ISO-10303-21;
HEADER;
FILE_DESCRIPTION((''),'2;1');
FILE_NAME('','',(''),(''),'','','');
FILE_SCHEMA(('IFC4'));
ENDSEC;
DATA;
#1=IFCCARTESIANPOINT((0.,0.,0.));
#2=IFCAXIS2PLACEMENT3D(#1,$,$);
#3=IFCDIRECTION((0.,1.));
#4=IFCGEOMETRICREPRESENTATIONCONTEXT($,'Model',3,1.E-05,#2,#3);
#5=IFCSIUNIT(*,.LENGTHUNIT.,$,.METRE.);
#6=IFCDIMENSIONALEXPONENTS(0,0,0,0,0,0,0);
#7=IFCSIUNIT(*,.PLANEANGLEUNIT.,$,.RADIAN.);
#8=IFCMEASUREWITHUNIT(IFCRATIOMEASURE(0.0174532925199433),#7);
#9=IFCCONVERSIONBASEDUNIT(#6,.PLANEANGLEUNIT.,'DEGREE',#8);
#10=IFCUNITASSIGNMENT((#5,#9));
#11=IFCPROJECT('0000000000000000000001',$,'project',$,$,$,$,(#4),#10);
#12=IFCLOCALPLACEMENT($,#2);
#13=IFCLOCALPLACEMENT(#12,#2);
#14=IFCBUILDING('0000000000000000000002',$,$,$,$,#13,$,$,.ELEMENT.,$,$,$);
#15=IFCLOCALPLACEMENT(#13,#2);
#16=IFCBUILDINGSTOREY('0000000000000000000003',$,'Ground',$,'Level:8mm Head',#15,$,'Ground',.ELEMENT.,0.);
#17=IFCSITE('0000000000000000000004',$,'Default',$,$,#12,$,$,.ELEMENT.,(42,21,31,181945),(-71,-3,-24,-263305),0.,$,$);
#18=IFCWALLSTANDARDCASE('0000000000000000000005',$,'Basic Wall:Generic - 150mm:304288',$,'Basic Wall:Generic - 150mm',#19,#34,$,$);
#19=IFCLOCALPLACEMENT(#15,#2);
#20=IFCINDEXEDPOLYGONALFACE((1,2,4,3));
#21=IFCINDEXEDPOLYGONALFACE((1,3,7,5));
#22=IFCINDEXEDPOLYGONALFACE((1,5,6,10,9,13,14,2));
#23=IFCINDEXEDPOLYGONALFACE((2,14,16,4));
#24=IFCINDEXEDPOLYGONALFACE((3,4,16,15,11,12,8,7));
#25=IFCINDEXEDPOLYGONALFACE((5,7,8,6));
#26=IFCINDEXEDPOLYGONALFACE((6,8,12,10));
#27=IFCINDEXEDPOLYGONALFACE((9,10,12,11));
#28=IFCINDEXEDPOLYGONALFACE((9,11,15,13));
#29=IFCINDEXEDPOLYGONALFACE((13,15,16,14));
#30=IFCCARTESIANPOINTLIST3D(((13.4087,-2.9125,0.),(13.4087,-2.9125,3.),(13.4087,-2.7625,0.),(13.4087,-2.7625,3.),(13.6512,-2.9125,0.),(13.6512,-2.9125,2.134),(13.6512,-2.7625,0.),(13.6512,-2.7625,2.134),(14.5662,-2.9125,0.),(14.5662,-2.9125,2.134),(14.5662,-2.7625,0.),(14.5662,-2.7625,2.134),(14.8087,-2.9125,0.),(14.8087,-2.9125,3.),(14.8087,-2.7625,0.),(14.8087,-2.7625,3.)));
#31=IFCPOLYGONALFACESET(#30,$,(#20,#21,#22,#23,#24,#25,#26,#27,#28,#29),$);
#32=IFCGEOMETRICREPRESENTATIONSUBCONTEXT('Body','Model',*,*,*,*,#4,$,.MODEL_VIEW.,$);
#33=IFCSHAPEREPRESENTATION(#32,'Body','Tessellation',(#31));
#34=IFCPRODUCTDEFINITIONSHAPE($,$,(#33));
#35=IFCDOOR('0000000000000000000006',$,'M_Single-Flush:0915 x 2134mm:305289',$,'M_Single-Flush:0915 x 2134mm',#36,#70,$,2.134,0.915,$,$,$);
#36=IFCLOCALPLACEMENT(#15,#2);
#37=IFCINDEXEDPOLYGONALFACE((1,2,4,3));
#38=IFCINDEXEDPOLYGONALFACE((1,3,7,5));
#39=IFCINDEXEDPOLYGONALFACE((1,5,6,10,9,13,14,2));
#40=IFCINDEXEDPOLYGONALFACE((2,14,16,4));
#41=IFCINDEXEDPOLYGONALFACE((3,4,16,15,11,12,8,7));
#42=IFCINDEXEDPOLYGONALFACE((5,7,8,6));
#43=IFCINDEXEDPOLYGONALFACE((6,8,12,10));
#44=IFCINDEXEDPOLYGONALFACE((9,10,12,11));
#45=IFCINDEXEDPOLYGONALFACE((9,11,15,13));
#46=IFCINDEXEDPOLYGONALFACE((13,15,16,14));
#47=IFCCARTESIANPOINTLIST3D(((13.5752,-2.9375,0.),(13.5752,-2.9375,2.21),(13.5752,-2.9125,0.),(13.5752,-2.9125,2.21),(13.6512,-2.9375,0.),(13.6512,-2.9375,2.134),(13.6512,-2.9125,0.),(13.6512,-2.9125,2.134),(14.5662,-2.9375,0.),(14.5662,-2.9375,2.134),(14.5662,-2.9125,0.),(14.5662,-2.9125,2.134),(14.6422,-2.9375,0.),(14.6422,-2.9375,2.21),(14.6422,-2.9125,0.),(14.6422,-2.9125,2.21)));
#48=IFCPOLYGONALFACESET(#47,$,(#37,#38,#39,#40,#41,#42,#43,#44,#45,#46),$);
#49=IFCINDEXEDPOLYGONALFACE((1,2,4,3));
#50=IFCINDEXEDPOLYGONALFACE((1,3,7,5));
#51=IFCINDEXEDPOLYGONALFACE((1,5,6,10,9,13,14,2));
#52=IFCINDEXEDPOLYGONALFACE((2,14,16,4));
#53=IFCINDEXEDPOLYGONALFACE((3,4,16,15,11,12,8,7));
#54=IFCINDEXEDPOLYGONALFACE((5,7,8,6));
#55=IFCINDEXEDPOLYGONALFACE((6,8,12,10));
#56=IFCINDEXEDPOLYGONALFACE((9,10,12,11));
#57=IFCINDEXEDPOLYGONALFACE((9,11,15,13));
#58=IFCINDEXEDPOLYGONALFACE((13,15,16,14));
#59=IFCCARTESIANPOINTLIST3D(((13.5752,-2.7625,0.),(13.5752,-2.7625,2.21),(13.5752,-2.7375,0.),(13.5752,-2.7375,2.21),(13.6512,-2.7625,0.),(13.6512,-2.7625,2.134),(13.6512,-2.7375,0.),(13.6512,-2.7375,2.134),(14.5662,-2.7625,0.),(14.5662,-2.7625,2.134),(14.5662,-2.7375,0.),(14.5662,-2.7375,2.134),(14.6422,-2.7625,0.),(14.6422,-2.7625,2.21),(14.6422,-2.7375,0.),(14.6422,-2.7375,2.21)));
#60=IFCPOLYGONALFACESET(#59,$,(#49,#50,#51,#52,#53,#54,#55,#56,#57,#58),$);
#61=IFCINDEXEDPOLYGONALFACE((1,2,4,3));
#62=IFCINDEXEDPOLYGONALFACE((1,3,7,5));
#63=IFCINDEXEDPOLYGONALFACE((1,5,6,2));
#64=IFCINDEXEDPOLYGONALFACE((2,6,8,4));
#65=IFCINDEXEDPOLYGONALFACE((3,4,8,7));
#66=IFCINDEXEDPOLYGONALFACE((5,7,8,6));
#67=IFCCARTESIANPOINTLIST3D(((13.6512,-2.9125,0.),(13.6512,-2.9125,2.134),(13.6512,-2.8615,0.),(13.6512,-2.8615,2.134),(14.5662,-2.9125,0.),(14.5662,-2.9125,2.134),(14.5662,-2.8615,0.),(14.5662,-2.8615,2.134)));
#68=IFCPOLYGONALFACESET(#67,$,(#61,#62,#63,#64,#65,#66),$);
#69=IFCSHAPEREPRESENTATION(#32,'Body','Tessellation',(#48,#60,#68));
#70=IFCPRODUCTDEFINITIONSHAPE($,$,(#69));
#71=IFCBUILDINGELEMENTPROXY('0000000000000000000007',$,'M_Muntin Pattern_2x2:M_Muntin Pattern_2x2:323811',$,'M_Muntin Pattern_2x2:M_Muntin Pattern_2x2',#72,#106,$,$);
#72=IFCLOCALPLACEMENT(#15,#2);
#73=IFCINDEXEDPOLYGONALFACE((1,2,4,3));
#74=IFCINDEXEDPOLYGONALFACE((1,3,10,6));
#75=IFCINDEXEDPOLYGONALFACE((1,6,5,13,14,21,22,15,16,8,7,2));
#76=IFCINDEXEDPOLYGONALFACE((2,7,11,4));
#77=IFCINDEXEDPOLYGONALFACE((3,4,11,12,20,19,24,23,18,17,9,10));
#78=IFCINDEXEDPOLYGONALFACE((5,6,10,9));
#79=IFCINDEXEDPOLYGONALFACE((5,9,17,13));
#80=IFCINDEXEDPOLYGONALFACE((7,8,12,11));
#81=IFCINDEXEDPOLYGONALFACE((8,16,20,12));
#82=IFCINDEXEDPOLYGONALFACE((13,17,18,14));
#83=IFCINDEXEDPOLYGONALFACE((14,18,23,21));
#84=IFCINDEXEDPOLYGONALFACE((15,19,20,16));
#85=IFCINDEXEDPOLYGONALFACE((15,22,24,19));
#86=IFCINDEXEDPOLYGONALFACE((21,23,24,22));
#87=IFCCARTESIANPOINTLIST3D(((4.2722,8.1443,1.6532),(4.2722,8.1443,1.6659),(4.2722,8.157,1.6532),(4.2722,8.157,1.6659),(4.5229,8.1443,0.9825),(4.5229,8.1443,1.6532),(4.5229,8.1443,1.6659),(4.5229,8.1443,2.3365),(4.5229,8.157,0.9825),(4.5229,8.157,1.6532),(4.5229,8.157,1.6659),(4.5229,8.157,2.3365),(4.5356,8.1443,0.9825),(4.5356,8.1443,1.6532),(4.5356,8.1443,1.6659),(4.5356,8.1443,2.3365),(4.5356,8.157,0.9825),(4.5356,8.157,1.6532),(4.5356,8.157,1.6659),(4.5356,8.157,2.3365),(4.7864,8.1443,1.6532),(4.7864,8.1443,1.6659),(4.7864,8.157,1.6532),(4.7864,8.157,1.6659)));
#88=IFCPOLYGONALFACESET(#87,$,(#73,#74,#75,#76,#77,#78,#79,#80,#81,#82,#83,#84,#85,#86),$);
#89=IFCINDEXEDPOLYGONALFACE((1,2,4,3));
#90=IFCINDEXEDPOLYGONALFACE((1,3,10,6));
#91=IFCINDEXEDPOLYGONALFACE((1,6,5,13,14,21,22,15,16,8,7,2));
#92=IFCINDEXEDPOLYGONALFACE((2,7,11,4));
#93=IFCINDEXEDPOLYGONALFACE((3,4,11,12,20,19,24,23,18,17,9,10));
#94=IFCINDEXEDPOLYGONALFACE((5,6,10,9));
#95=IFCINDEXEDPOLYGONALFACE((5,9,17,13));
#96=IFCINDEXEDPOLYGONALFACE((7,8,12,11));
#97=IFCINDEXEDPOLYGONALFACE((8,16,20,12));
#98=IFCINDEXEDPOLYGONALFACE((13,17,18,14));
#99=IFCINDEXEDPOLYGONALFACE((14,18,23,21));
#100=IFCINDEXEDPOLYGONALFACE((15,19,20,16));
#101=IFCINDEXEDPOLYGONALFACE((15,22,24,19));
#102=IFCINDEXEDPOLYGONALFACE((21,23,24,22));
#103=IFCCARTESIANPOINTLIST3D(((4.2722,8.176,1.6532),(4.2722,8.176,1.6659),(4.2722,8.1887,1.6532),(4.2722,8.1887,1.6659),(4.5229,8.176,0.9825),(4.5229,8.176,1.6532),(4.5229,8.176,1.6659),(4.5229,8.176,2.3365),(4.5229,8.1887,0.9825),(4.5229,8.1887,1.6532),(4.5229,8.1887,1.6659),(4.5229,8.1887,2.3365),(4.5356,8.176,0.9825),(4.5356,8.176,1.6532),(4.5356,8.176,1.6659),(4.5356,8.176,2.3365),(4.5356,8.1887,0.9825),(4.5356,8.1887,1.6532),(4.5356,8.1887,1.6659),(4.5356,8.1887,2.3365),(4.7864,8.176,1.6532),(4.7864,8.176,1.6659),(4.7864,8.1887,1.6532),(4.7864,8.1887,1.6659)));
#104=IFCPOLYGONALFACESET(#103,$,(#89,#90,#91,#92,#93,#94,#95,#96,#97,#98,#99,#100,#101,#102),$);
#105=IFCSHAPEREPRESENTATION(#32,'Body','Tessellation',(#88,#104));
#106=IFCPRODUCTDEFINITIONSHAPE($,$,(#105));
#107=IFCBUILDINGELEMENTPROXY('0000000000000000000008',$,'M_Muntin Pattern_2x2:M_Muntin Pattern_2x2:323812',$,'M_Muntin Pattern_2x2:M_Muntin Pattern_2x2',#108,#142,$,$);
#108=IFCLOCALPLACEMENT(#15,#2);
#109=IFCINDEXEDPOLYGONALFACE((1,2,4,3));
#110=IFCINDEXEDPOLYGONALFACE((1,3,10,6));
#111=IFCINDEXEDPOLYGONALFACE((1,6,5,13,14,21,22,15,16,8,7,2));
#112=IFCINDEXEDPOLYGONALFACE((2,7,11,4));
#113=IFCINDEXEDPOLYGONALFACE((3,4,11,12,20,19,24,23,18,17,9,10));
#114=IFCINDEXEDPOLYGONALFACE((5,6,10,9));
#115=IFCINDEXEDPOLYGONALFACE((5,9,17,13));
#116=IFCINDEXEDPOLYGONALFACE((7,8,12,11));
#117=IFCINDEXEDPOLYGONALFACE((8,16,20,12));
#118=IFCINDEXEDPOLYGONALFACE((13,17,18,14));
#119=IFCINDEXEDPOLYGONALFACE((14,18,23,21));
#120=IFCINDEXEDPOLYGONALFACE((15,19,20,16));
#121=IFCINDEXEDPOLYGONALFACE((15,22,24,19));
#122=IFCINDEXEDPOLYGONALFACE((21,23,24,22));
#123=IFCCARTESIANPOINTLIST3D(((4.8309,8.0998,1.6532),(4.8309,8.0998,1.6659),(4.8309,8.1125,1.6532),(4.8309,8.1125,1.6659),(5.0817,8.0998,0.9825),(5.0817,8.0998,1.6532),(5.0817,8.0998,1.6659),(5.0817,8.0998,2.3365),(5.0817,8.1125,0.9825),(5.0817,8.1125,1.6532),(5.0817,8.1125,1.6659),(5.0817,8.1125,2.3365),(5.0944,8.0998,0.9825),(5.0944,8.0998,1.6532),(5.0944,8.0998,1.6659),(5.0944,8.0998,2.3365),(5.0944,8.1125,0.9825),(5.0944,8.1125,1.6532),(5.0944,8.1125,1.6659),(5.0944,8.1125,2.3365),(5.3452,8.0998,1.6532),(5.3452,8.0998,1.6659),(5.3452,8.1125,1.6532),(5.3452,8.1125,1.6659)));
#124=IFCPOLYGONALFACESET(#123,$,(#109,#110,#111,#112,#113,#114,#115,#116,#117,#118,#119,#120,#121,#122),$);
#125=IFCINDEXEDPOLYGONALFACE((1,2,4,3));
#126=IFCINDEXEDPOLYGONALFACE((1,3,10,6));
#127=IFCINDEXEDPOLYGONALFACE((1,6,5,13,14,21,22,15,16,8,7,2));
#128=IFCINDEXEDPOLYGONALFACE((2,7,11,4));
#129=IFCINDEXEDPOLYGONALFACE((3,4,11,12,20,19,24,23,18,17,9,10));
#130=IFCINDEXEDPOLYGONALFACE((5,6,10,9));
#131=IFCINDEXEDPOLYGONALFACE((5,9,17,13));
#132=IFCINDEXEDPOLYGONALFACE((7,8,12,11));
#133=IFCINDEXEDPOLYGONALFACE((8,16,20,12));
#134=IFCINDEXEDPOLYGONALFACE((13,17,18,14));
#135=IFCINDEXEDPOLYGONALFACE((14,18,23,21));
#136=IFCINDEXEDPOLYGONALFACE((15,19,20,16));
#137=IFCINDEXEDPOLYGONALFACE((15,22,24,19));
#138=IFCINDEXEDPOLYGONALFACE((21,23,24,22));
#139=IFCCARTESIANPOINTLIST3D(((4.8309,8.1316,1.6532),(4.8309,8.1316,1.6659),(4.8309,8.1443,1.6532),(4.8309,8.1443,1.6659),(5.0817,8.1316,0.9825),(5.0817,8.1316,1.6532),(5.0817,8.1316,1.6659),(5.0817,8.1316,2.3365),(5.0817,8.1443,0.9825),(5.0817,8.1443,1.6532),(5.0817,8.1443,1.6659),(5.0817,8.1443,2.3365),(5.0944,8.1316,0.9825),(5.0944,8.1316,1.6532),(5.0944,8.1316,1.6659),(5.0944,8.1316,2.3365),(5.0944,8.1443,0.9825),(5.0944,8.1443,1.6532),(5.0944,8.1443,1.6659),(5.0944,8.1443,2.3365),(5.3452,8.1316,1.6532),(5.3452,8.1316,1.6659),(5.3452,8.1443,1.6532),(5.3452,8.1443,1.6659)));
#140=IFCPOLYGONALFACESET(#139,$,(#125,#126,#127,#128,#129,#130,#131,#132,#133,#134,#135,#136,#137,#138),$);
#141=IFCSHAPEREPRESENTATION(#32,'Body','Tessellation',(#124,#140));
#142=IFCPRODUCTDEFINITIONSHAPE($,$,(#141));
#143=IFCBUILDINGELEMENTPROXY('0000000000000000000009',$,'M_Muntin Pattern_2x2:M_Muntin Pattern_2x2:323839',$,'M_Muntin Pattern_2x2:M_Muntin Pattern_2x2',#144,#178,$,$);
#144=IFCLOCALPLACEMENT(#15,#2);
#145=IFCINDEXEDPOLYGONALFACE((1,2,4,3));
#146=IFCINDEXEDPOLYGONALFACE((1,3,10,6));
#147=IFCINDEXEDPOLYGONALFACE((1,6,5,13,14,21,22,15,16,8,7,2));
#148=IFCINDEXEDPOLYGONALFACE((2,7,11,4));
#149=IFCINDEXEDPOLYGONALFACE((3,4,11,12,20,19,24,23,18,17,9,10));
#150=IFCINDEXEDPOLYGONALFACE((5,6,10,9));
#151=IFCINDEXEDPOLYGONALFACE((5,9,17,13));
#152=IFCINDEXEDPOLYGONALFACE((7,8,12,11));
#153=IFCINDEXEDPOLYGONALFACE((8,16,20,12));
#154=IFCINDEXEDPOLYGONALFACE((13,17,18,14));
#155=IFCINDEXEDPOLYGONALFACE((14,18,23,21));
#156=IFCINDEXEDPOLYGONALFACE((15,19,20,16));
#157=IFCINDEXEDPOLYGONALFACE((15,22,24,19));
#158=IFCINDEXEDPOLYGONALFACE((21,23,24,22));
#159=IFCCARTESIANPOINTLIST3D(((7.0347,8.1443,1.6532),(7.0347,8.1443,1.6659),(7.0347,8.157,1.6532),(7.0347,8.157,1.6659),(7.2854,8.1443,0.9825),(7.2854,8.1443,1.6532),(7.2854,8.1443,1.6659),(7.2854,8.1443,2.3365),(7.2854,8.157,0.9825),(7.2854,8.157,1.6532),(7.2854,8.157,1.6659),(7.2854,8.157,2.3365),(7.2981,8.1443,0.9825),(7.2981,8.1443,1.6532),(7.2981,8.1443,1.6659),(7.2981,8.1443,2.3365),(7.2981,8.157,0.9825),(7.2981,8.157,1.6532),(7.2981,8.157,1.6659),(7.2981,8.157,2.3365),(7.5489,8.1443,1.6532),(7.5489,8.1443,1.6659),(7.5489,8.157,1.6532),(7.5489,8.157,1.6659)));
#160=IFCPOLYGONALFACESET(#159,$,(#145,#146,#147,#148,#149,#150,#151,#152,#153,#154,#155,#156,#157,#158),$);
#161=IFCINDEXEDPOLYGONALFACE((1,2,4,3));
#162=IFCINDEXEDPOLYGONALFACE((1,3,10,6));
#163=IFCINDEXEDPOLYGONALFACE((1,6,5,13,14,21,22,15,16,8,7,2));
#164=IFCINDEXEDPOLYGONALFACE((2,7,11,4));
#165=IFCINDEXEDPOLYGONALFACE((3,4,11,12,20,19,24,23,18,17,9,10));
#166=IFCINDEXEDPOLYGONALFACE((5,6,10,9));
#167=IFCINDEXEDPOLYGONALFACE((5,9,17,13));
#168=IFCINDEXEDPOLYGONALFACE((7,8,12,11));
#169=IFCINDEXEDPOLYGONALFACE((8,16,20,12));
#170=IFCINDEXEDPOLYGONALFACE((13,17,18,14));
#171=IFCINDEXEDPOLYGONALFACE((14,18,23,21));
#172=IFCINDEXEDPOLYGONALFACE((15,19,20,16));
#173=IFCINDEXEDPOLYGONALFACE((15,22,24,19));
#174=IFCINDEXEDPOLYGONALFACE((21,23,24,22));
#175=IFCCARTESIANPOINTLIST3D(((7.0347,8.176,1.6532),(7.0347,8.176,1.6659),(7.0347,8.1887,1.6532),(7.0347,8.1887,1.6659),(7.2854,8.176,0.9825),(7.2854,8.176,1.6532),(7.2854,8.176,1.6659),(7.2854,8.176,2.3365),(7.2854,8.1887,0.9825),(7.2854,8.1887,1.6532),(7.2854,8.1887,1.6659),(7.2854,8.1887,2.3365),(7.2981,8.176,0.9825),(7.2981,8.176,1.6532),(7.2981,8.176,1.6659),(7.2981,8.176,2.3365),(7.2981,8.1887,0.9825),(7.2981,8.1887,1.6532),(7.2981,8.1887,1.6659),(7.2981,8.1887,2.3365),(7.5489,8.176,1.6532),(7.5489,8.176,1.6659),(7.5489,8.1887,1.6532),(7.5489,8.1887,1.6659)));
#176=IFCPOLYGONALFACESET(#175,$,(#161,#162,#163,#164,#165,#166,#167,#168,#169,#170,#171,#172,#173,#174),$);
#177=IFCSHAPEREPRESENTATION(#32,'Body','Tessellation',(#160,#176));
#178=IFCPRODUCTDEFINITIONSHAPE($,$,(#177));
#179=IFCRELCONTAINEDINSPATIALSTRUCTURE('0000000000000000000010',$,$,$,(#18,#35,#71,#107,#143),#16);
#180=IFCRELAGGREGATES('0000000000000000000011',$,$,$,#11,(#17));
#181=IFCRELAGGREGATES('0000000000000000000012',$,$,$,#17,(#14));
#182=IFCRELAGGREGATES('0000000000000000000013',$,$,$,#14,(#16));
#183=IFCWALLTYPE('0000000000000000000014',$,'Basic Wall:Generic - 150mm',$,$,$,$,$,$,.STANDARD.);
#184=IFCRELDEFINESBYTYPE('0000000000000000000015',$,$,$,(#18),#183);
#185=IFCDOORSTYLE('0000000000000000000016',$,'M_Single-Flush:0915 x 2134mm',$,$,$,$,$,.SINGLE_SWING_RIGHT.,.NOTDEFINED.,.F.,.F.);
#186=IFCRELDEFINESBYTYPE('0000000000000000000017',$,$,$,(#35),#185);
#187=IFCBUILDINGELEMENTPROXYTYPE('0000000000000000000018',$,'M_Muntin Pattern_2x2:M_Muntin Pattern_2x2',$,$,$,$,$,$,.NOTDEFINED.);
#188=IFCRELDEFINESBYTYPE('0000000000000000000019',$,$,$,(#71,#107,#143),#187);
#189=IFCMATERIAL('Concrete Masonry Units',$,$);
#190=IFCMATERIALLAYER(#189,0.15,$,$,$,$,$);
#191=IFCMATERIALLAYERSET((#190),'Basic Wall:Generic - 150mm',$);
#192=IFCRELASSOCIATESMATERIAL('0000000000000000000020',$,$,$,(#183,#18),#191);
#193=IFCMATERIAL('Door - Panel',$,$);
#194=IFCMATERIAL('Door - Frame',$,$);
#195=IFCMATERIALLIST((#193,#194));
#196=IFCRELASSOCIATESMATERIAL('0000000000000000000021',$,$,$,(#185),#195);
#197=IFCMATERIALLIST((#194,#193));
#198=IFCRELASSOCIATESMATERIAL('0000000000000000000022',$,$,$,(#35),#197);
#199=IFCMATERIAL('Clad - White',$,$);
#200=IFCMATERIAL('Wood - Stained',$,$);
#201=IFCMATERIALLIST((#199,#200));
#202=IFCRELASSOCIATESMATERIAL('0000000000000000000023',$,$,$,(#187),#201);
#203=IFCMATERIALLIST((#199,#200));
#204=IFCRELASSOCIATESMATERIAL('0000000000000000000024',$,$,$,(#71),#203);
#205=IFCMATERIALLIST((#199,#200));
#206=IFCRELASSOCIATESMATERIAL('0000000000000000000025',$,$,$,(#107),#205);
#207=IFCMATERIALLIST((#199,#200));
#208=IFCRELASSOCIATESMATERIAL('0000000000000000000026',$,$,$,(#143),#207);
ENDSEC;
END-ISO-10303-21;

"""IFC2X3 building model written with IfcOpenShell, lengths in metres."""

from ifc_helpers import new_model, entity, si_unit, converted_unit, direction, frame, frame_2d, origin, place, context, subcontext, project, spatial, polyline, rectangle, outline, extrude, source, transform, mapped, material, material_list, layer, layer_set, layer_usage, type_object, type_shapes, element, fill, save


model = new_model("IFC2X3")

# Units and contexts
model_context = context("Model", 3, precision=1e-05, world=origin(), true_north=direction((0.0, 1.0)))
body_context = subcontext(model_context, "Body", "Model", "MODEL_VIEW")
ifc_project = project(units=[si_unit("LENGTHUNIT", "METRE"), converted_unit("PLANEANGLEUNIT", "DEGREE", entity("IfcRatioMeasure", 0.0174532925199433), si_unit("PLANEANGLEUNIT", "RADIAN"), dimensions=[0, 0, 0, 0, 0, 0, 0])], contexts=[model_context])

# Site, building, storey
site_placement = place(None, origin())
site = spatial("IfcSite", under=ifc_project, at=site_placement, Name="Default", CompositionType="ELEMENT", RefLatitude=(42, 21, 31, 181945), RefLongitude=(-71, -3, -24, -263305), RefElevation=0.0)
building_placement = place(site_placement, origin())
building = spatial("IfcBuilding", under=site, at=building_placement, CompositionType="ELEMENT")
storey_placement = place(building_placement, origin())
storey = spatial("IfcBuildingStorey", under=building, at=storey_placement, Name="Ground", ObjectType="Level:8mm Head", LongName="Ground", CompositionType="ELEMENT", Elevation=0.0)

# Shared definitions
ifc_material_1 = material(Name="Concrete Masonry Units")
ifc_layer = layer(ifc_material_1, 0.15)
ifc_layer_set = layer_set([ifc_layer], Name="Basic Wall:Generic - 150mm")
wall_type = type_object("IfcWallType", Name="Basic Wall:Generic - 150mm", PredefinedType="STANDARD", material=ifc_layer_set)

# Shared definitions
ifc_material_2 = material(Name="Door - Frame")
ifc_material_3 = material(Name="Door - Panel")

# Wall, opening, door
ifc_layer_usage_1 = layer_usage(ifc_layer_set, "AXIS2", "NEGATIVE", 0.075)
wall_1_placement = place(storey_placement, frame((14.8087, -2.8375, 0.0), z_axis=(0.0, 0.0, 1.0), x_axis=(-1.0, 0.0, 0.0)))
wall_1 = element("IfcWallStandardCase", 1, at=wall_1_placement, inside=storey, type_object=wall_type, material=ifc_layer_usage_1, Name="Basic Wall:Generic - 150mm:304288", ObjectType="Basic Wall:Generic - 150mm", context=body_context, shape_type="SweptSolid", body=[
    extrude(rectangle(XDim=1.4, YDim=0.15, at=frame_2d((0.7, 0.0), x_axis=(-1.0, 0.0))), origin(), (0.0, 0.0, 1.0), 3.0),
])
opening_1_placement = place(wall_1_placement, frame((0.2425, -0.075, 0.0)))
opening_1 = element("IfcOpeningElement", 2, at=opening_1_placement, cuts=wall_1, ObjectType="Opening", context=body_context, shape_type="SweptSolid", body=[
    extrude(rectangle(XDim=0.915, YDim=2.134, at=frame_2d((1.067, 0.4575), x_axis=(0.0, 1.0))), frame((0.0, 0.0, 0.0), z_axis=(0.0, 1.0, 0.0), x_axis=(0.0, 0.0, 1.0)), (0.0, 0.0, 1.0), 0.15),
])
ifc_material_list_1 = material_list([ifc_material_2, ifc_material_3])
ifc_material_list_2 = material_list([ifc_material_3, ifc_material_2])
door_style_1 = type_object("IfcDoorStyle", Name="M_Single-Flush:0915 x 2134mm", ConstructionType="NOTDEFINED", OperationType="SINGLE_SWING_RIGHT", ParameterTakesPrecedence=False, Sizeable=False, material=ifc_material_list_2)
shared_shape_1 = source(origin(), body_context, "Body", "SweptSolid", [
    extrude(outline(polyline([(-0.5335, -1.124), (0.5335, -1.124), (0.5335, 1.086), (0.4575, 1.086), (0.4575, -1.048), (-0.4575, -1.048), (-0.4575, 1.086), (-0.5335, 1.086), (-0.5335, -1.124)])), frame((0.4575, 0.15, 1.086), z_axis=(0.0, 1.0, 0.0), x_axis=(1.0, 0.0, 0.0)), (0.0, 0.0, 1.0), 0.025),
    extrude(outline(polyline([(-1.124, -0.5335), (1.086, -0.5335), (1.086, -0.4575), (-1.048, -0.4575), (-1.048, 0.4575), (1.086, 0.4575), (1.086, 0.5335), (-1.124, 0.5335), (-1.124, -0.5335)])), frame((0.4575, -0.025, 1.086), z_axis=(0.0, 1.0, 0.0), x_axis=(0.0, 0.0, -1.0)), (0.0, 0.0, 1.0), 0.025),
    extrude(rectangle(XDim=0.051, YDim=0.915, at=frame_2d((0.0, 0.0), x_axis=(1.0, 0.0))), frame((0.4575, 0.1245, 0.0), z_axis=(0.0, 0.0, 1.0), x_axis=(0.0, 1.0, 0.0)), (0.0, 0.0, 1.0), 2.134),
])
type_shapes(door_style_1, [shared_shape_1])
door_1_placement = place(opening_1_placement, origin())
door_1 = element("IfcDoor", 3, at=door_1_placement, inside=storey, type_object=door_style_1, material=ifc_material_list_1, Name="M_Single-Flush:0915 x 2134mm:305289", ObjectType="M_Single-Flush:0915 x 2134mm", OverallHeight=2.134, OverallWidth=0.915, context=body_context, shape_type="MappedRepresentation", body=[
    mapped(shared_shape_1, transform((0.0, 0.0, 0.0), scale=1.0)),
])
fill(opening_1, door_1)

# Building element proxies
ifc_material_4 = material(Name="Clad - White")
ifc_material_5 = material(Name="Wood - Stained")
ifc_material_list_3 = material_list([ifc_material_4, ifc_material_5])
ifc_material_list_4 = material_list([ifc_material_4, ifc_material_5])
building_element_proxy_type_1 = type_object("IfcBuildingElementProxyType", Name="M_Muntin Pattern_2x2:M_Muntin Pattern_2x2", PredefinedType="NOTDEFINED", material=ifc_material_list_4)
shared_shape_2 = source(origin(), body_context, "Body", "SweptSolid", [
    extrude(outline(polyline([(0.0064, -0.0064), (0.677, -0.0064), (0.677, 0.0063), (0.0064, 0.0063), (0.0064, 0.2571), (-0.0063, 0.2571), (-0.0063, 0.0063), (-0.677, 0.0063), (-0.677, -0.0064), (-0.0063, -0.0064), (-0.0063, -0.2571), (0.0064, -0.2571), (0.0064, -0.0064)])), frame((0.0, 0.0095, 0.677), z_axis=(0.0, 1.0, 0.0), x_axis=(0.0, 0.0, 1.0)), (0.0, 0.0, 1.0), 0.0127),
    extrude(outline(polyline([(0.0064, -0.0064), (0.677, -0.0064), (0.677, 0.0063), (0.0064, 0.0063), (0.0064, 0.2571), (-0.0063, 0.2571), (-0.0063, 0.0063), (-0.677, 0.0063), (-0.677, -0.0064), (-0.0063, -0.0064), (-0.0063, -0.2571), (0.0064, -0.2571), (0.0064, -0.0064)])), frame((0.0, -0.0222, 0.677), z_axis=(0.0, 1.0, 0.0), x_axis=(0.0, 0.0, 1.0)), (0.0, 0.0, 1.0), 0.0127),
])
type_shapes(building_element_proxy_type_1, [shared_shape_2])
proxy_1_placement = place(storey_placement, frame((4.5293, 8.1665, 0.9825), z_axis=(0.0, 0.0, 1.0), x_axis=(-1.0, 0.0, 0.0)))
element("IfcBuildingElementProxy", 4, at=proxy_1_placement, inside=storey, type_object=building_element_proxy_type_1, material=ifc_material_list_3, Name="M_Muntin Pattern_2x2:M_Muntin Pattern_2x2:323811", ObjectType="M_Muntin Pattern_2x2:M_Muntin Pattern_2x2", context=body_context, shape_type="MappedRepresentation", body=[
    mapped(shared_shape_2, transform((0.0, 0.0, 0.0), scale=1.0)),
])
ifc_material_list_5 = material_list([ifc_material_4, ifc_material_5])
proxy_2_placement = place(storey_placement, frame((5.088, 8.1221, 0.9825), z_axis=(0.0, 0.0, 1.0), x_axis=(-1.0, 0.0, 0.0)))
element("IfcBuildingElementProxy", 5, at=proxy_2_placement, inside=storey, type_object=building_element_proxy_type_1, material=ifc_material_list_5, Name="M_Muntin Pattern_2x2:M_Muntin Pattern_2x2:323812", ObjectType="M_Muntin Pattern_2x2:M_Muntin Pattern_2x2", context=body_context, shape_type="MappedRepresentation", body=[
    mapped(shared_shape_2, transform((0.0, 0.0, 0.0), scale=1.0)),
])
ifc_material_list_6 = material_list([ifc_material_4, ifc_material_5])
proxy_3_placement = place(storey_placement, frame((7.2918, 8.1665, 0.9825), z_axis=(0.0, 0.0, 1.0), x_axis=(-1.0, 0.0, 0.0)))
element("IfcBuildingElementProxy", 6, at=proxy_3_placement, inside=storey, type_object=building_element_proxy_type_1, material=ifc_material_list_6, Name="M_Muntin Pattern_2x2:M_Muntin Pattern_2x2:323839", ObjectType="M_Muntin Pattern_2x2:M_Muntin Pattern_2x2", context=body_context, shape_type="MappedRepresentation", body=[
    mapped(shared_shape_2, transform((0.0, 0.0, 0.0), scale=1.0)),
])

save(model, "model.ifc")
